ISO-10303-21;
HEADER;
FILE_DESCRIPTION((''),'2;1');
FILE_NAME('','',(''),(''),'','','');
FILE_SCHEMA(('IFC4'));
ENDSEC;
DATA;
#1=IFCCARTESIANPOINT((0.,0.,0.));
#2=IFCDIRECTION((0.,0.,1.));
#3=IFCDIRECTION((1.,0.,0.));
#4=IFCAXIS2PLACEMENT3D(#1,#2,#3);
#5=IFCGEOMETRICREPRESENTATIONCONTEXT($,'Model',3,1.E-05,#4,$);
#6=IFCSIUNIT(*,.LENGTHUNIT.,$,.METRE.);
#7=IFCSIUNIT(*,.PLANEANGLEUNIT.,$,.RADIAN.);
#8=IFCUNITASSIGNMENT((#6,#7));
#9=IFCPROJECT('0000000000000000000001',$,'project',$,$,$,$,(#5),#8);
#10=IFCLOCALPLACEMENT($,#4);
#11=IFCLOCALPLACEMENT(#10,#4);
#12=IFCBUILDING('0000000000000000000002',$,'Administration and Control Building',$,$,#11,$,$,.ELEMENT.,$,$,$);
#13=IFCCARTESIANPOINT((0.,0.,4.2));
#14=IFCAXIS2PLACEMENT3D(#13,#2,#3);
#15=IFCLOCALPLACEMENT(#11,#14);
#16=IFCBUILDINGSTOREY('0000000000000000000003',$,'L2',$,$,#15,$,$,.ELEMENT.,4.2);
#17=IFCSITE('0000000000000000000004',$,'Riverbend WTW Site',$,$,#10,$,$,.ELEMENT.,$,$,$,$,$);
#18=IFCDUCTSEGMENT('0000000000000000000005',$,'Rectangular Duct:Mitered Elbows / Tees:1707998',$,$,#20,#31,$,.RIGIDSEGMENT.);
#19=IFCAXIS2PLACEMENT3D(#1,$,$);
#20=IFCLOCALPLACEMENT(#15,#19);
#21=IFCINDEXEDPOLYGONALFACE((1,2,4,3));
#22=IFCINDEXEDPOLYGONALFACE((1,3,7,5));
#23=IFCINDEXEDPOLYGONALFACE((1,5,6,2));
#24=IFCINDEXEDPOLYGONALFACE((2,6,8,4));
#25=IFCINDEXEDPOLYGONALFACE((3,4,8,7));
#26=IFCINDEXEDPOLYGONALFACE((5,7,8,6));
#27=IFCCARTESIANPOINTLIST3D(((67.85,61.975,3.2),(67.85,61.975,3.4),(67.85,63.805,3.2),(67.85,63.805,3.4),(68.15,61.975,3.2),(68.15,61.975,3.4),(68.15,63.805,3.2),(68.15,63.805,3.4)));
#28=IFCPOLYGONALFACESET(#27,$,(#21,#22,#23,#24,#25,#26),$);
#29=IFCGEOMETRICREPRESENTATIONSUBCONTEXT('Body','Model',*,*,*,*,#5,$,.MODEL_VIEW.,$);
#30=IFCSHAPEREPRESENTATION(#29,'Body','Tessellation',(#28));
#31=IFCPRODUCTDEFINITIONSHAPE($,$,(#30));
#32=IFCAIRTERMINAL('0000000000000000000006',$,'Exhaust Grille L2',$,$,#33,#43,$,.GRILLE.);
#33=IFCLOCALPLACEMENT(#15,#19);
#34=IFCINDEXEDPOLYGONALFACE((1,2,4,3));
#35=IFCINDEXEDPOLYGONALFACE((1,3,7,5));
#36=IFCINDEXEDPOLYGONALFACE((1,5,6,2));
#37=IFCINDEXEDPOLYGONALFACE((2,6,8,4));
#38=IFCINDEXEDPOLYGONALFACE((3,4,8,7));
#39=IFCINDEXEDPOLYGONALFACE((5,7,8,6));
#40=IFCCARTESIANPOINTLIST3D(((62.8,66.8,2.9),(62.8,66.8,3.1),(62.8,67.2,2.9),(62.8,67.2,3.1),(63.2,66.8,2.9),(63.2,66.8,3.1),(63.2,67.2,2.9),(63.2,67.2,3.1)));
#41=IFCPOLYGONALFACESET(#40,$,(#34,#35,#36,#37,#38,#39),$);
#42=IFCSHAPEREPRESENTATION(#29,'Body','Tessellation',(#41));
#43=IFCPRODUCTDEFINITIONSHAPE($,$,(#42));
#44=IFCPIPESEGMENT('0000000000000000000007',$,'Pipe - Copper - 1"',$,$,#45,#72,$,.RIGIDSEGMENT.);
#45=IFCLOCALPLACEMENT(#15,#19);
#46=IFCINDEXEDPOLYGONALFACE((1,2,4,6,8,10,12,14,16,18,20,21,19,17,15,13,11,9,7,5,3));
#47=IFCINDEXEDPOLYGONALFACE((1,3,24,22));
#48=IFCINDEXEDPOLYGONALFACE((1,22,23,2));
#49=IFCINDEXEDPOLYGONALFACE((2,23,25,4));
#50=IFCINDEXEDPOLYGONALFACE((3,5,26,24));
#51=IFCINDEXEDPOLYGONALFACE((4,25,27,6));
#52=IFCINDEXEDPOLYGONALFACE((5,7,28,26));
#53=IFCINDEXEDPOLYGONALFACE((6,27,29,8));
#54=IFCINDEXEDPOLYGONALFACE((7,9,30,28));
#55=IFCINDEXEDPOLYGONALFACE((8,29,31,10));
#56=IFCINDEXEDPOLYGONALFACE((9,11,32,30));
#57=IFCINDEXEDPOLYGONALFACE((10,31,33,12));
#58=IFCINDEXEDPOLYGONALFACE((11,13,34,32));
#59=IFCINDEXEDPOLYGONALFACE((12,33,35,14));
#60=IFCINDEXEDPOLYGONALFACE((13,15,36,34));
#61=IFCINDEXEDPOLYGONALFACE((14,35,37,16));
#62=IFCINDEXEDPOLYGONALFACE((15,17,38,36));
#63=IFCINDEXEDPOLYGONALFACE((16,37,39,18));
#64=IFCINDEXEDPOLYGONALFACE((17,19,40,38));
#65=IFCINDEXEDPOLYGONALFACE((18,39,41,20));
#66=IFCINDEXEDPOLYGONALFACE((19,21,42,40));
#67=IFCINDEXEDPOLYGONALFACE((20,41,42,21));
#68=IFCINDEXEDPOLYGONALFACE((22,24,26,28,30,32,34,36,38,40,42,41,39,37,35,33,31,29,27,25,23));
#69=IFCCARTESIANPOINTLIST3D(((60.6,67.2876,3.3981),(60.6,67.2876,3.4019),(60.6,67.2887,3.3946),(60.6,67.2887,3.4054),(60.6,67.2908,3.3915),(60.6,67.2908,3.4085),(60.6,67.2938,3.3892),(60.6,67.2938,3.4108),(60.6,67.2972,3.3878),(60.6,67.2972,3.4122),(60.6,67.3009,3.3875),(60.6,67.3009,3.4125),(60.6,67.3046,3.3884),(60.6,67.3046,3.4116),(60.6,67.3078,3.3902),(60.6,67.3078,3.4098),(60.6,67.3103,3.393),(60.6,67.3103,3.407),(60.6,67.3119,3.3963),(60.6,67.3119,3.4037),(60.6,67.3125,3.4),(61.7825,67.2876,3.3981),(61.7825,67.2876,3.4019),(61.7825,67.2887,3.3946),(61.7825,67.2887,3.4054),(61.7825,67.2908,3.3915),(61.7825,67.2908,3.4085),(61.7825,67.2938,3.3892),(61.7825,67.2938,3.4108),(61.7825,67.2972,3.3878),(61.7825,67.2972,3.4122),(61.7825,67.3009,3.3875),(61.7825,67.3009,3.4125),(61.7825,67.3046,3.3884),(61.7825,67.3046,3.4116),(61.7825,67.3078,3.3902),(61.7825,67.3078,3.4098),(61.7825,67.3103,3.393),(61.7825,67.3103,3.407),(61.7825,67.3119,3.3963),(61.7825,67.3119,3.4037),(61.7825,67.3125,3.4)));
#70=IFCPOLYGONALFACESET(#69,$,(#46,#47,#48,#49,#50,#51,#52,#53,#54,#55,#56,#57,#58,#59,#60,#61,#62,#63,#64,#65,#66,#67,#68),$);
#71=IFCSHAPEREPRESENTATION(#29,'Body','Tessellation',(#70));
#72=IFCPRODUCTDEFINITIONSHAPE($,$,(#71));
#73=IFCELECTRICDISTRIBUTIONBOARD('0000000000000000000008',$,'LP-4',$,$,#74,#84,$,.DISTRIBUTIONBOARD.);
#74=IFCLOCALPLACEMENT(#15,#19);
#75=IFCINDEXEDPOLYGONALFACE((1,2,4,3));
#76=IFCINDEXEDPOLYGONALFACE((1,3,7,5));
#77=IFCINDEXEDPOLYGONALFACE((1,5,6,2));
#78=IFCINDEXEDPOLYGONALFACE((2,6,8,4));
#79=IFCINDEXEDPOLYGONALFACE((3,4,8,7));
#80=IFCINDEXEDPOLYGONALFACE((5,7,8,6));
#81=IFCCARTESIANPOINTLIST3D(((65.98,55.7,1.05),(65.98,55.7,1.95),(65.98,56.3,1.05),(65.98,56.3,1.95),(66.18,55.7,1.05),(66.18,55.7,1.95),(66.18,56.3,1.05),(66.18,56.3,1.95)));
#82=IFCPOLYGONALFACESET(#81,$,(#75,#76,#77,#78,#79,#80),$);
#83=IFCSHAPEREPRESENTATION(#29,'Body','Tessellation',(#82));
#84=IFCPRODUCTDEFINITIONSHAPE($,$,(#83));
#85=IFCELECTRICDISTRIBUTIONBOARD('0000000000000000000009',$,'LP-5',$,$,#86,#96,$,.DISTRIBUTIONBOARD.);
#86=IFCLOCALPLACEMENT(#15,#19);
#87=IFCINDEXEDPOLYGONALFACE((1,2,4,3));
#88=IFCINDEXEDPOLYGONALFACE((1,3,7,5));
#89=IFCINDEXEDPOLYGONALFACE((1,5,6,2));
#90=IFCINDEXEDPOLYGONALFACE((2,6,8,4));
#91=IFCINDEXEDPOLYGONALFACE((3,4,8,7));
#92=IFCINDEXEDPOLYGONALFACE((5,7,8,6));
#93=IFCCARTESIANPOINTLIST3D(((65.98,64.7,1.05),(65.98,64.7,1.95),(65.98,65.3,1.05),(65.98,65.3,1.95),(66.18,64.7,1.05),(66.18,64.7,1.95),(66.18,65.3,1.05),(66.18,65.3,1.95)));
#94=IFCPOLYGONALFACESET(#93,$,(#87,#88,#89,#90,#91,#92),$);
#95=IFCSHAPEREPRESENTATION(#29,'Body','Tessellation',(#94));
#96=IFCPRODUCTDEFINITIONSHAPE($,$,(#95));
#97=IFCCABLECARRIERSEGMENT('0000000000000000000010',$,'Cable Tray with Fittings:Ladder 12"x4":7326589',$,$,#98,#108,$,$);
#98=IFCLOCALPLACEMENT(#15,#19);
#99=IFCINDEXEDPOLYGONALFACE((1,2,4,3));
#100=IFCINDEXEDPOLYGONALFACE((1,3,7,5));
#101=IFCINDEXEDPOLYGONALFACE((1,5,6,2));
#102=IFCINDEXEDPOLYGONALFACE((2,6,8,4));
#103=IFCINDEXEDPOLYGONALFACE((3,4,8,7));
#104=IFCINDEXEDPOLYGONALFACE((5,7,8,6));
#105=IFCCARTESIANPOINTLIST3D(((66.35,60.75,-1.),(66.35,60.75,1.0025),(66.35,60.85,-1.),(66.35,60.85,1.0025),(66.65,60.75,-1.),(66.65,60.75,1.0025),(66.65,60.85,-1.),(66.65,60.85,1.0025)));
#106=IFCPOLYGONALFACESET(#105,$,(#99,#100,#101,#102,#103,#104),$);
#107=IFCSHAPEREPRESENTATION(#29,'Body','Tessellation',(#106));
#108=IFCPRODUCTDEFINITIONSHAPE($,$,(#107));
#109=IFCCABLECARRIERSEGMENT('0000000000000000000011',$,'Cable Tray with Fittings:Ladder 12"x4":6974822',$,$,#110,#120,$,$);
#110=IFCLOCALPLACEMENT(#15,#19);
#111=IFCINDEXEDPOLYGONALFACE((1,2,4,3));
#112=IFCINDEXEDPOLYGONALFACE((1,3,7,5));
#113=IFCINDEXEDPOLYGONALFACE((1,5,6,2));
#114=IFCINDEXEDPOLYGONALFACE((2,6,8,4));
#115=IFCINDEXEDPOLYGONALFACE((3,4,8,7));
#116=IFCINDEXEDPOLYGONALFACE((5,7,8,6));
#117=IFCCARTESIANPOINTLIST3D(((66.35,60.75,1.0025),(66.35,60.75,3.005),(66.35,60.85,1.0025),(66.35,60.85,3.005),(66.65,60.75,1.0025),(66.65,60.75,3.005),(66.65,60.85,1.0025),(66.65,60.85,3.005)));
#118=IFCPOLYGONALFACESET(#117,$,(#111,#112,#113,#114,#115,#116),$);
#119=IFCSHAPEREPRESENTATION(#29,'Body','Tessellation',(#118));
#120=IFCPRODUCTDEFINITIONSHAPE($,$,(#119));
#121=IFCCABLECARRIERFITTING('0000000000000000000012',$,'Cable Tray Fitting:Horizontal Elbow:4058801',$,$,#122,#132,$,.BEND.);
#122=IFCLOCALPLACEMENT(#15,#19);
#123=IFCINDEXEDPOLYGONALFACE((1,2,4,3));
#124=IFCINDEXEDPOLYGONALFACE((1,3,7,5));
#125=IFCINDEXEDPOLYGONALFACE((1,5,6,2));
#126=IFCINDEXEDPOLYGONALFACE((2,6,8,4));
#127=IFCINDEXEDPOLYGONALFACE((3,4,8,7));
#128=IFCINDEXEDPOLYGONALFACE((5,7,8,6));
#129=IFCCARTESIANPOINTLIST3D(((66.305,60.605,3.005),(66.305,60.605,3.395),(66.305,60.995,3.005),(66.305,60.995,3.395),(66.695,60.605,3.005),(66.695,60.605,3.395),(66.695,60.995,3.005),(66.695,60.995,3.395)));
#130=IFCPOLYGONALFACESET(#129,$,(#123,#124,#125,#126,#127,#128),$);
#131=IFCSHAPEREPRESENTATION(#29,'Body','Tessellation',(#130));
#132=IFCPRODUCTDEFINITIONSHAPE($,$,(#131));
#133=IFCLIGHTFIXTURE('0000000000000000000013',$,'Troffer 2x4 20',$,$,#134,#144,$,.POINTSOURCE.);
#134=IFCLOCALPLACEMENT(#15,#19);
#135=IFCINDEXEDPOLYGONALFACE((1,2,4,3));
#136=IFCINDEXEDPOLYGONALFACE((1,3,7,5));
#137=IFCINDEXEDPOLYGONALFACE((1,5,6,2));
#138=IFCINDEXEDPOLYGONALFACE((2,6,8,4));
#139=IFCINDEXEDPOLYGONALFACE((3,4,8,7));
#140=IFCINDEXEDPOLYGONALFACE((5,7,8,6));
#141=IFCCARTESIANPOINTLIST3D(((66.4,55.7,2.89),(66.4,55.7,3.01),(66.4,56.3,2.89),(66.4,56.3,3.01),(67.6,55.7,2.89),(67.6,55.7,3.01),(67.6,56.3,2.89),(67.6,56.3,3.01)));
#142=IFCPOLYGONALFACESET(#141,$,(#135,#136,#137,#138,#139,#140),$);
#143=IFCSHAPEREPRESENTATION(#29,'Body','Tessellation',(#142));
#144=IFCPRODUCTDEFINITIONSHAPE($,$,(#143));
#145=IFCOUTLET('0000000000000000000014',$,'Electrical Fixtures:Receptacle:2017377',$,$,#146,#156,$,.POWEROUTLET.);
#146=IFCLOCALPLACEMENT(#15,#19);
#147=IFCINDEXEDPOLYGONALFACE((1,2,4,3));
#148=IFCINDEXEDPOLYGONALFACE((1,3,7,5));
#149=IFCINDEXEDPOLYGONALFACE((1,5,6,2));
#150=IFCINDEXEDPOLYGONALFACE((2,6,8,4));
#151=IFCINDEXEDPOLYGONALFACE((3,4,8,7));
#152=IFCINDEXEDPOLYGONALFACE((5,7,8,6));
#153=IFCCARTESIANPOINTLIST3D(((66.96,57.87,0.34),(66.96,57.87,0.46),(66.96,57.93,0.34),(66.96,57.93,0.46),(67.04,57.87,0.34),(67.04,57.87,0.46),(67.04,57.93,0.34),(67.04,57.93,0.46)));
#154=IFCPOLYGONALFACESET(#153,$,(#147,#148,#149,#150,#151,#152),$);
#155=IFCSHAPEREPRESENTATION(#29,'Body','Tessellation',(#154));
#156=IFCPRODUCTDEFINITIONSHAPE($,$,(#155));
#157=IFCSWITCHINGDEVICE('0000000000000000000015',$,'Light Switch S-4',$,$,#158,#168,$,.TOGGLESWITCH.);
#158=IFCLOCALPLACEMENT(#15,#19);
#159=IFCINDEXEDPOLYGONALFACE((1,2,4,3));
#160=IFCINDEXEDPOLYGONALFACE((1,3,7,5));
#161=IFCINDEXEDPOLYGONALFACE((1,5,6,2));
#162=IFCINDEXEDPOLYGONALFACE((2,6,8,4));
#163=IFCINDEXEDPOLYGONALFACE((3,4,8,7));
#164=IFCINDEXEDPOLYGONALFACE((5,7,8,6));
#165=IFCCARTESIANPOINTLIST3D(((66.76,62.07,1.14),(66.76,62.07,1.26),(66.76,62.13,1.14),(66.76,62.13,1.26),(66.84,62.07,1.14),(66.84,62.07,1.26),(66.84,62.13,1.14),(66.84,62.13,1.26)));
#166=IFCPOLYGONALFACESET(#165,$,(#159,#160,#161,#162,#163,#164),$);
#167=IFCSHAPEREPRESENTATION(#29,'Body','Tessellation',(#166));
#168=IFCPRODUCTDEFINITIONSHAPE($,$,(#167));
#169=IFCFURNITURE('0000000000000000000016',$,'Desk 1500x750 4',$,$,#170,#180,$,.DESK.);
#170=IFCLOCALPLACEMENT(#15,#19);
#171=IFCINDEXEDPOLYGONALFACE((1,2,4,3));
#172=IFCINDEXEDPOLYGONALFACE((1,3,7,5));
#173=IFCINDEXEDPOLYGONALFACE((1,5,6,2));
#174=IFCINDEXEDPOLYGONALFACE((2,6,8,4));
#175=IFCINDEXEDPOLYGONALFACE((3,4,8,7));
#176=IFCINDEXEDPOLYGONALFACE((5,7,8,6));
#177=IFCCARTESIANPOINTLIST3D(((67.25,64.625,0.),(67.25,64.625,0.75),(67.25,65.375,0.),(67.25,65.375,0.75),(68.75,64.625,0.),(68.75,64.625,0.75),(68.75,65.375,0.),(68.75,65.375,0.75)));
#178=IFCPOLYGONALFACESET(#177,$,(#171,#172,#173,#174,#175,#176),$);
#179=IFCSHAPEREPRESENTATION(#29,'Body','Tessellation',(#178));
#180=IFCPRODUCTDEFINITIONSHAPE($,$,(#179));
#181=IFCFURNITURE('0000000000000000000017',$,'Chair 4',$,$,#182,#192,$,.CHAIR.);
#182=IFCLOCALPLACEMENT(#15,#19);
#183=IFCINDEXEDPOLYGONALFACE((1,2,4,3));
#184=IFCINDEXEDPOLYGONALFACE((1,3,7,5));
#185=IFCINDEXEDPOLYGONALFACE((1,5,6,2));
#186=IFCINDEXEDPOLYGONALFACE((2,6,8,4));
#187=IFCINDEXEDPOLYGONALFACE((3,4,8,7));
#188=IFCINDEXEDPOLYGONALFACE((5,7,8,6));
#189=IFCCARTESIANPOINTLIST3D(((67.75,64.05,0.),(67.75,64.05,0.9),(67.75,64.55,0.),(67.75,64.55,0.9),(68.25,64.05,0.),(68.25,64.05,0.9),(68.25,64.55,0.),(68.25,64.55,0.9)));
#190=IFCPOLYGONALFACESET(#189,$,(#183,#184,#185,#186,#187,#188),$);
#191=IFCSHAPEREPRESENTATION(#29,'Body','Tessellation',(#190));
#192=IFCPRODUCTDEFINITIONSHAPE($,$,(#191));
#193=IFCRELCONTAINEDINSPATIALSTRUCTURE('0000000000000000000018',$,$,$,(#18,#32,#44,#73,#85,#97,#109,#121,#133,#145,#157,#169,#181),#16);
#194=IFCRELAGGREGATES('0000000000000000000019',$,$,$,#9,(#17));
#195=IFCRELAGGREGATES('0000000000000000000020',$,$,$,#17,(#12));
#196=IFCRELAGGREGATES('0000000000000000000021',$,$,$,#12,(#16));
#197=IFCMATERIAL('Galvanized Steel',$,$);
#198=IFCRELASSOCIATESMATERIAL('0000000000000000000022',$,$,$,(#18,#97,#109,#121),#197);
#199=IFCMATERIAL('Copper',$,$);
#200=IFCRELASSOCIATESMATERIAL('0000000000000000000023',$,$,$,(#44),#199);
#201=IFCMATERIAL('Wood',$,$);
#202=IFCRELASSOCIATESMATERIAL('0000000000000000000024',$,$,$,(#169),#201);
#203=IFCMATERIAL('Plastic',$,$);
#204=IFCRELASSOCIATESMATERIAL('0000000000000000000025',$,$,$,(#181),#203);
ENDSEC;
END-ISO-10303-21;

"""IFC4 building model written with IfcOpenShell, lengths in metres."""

from ifc_helpers import new_model, si_unit, frame, origin_with_axes, origin_2d, place, context, subcontext, project, spatial, rectangle, circle, extrude, material, element, save


model = new_model("IFC4")

# Units and contexts
model_context = context("Model", 3, precision=1e-05, world=origin_with_axes())
body_context = subcontext(model_context, "Body", "Model", "MODEL_VIEW")
ifc_project = project(units=[si_unit("LENGTHUNIT", "METRE"), si_unit("PLANEANGLEUNIT", "RADIAN")], contexts=[model_context])

# Site, building, storey
site_placement = place(None, origin_with_axes())
site = spatial("IfcSite", under=ifc_project, at=site_placement, Name="Riverbend WTW Site", CompositionType="ELEMENT")
building_placement = place(site_placement, origin_with_axes())
building = spatial("IfcBuilding", under=site, at=building_placement, Name="Administration and Control Building", CompositionType="ELEMENT")
storey_placement = place(building_placement, frame((0.0, 0.0, 4.2), z_axis=(0.0, 0.0, 1.0), x_axis=(1.0, 0.0, 0.0)))
storey = spatial("IfcBuildingStorey", under=building, at=storey_placement, Name="L2", CompositionType="ELEMENT", Elevation=4.2)

# Duct segment
ifc_material_1 = material(Name="Galvanized Steel")
duct_segment_1_placement = place(None, frame((68.0, 62.89, 7.5), z_axis=(0.0, 0.0, 1.0), x_axis=(1.0, 0.0, 0.0)))
element("IfcDuctSegment", 1, at=duct_segment_1_placement, inside=storey, material=ifc_material_1, Name="Rectangular Duct:Mitered Elbows / Tees:1707998", PredefinedType="RIGIDSEGMENT", context=body_context, shape_type="SweptSolid", body=[
    extrude(rectangle(XDim=0.3, YDim=1.83, at=origin_2d()), frame((0.0, 0.0, -0.1), z_axis=(0.0, 0.0, 1.0), x_axis=(1.0, 0.0, 0.0)), (0.0, 0.0, 1.0), 0.2),
])

# Air terminal
air_terminal_placement = place(None, frame((63.0, 67.0, 7.2), z_axis=(0.0, 0.0, 1.0), x_axis=(1.0, 0.0, 0.0)))
element("IfcAirTerminal", 2, at=air_terminal_placement, inside=storey, Name="Exhaust Grille L2", PredefinedType="GRILLE", context=body_context, shape_type="SweptSolid", body=[
    extrude(rectangle(XDim=0.4, YDim=0.4, at=origin_2d()), frame((0.0, 0.0, -0.1), z_axis=(0.0, 0.0, 1.0), x_axis=(1.0, 0.0, 0.0)), (0.0, 0.0, 1.0), 0.2),
])

# Pipe segment
ifc_material_2 = material(Name="Copper")
pipe_segment_placement = place(None, frame((60.6, 67.3, 7.6), z_axis=(0.0, 0.0, 1.0), x_axis=(1.0, 0.0, 0.0)))
element("IfcPipeSegment", 3, at=pipe_segment_placement, inside=storey, material=ifc_material_2, Name="Pipe - Copper - 1\"", PredefinedType="RIGIDSEGMENT", context=body_context, shape_type="SweptSolid", body=[
    extrude(circle(Radius=0.0125, at=origin_2d()), frame((0.0, 0.0, 0.0), z_axis=(1.0, 0.0, 0.0), x_axis=(0.0, 1.0, 0.0)), (0.0, 0.0, 1.0), 1.1825),
])

# Electric distribution boards
for number, where, z_axis, x_axis, name in (
    (4, (66.08, 56.0, 5.7), (0.0, 0.0, 1.0), (1.0, 0.0, 0.0), "LP-4"),
    (5, (66.08, 65.0, 5.7), (0.0, 0.0, 1.0), (1.0, 0.0, 0.0), "LP-5"),
):
    element("IfcElectricDistributionBoard", number, at=place(None, frame(where, z_axis=z_axis, x_axis=x_axis)), inside=storey, Name=name, PredefinedType="DISTRIBUTIONBOARD", context=body_context, shape_type="SweptSolid", body=[
        extrude(rectangle(XDim=0.2, YDim=0.6, at=origin_2d()), frame((0.0, 0.0, -0.45), z_axis=(0.0, 0.0, 1.0), x_axis=(1.0, 0.0, 0.0)), (0.0, 0.0, 1.0), 0.9),
    ])

# Cable carrier segments
cable_carrier_segment_1_placement = place(None, frame((66.5, 60.8, 4.2012), z_axis=(0.0, 0.0, 1.0), x_axis=(1.0, 0.0, 0.0)))
element("IfcCableCarrierSegment", 6, at=cable_carrier_segment_1_placement, inside=storey, material=ifc_material_1, Name="Cable Tray with Fittings:Ladder 12\"x4\":7326589", context=body_context, shape_type="SweptSolid", body=[
    extrude(rectangle(XDim=0.3, YDim=0.1, at=origin_2d()), frame((0.0, 0.0, -1.0013), z_axis=(0.0, 0.0, 1.0), x_axis=(1.0, 0.0, 0.0)), (0.0, 0.0, 1.0), 2.0025),
])
cable_carrier_segment_2_placement = place(None, frame((66.5, 60.8, 6.2038), z_axis=(0.0, 0.0, 1.0), x_axis=(1.0, 0.0, 0.0)))
element("IfcCableCarrierSegment", 7, at=cable_carrier_segment_2_placement, inside=storey, material=ifc_material_1, Name="Cable Tray with Fittings:Ladder 12\"x4\":6974822", context=body_context, shape_type="SweptSolid", body=[
    extrude(rectangle(XDim=0.3, YDim=0.1, at=origin_2d()), frame((0.0, 0.0, -1.0012), z_axis=(0.0, 0.0, 1.0), x_axis=(1.0, 0.0, 0.0)), (0.0, 0.0, 1.0), 2.0025),
])

# Cable carrier fitting
cable_carrier_fitting_placement = place(None, frame((66.5, 60.8, 7.4), z_axis=(0.0, 0.0, 1.0), x_axis=(1.0, 0.0, 0.0)))
element("IfcCableCarrierFitting", 8, at=cable_carrier_fitting_placement, inside=storey, material=ifc_material_1, Name="Cable Tray Fitting:Horizontal Elbow:4058801", PredefinedType="BEND", context=body_context, shape_type="SweptSolid", body=[
    extrude(rectangle(XDim=0.39, YDim=0.39, at=origin_2d()), frame((0.0, 0.0, -0.195), z_axis=(0.0, 0.0, 1.0), x_axis=(1.0, 0.0, 0.0)), (0.0, 0.0, 1.0), 0.39),
])

# Light fixture
light_fixture_placement = place(None, frame((67.0, 56.0, 7.15), z_axis=(0.0, 0.0, 1.0), x_axis=(1.0, 0.0, 0.0)))
element("IfcLightFixture", 9, at=light_fixture_placement, inside=storey, Name="Troffer 2x4 20", PredefinedType="POINTSOURCE", context=body_context, shape_type="SweptSolid", body=[
    extrude(rectangle(XDim=1.2, YDim=0.6, at=origin_2d()), frame((0.0, 0.0, -0.06), z_axis=(0.0, 0.0, 1.0), x_axis=(1.0, 0.0, 0.0)), (0.0, 0.0, 1.0), 0.12),
])

# Outlet
outlet_placement = place(None, frame((67.0, 57.9, 4.6), z_axis=(0.0, 0.0, 1.0), x_axis=(1.0, 0.0, 0.0)))
element("IfcOutlet", 10, at=outlet_placement, inside=storey, Name="Electrical Fixtures:Receptacle:2017377", PredefinedType="POWEROUTLET", context=body_context, shape_type="SweptSolid", body=[
    extrude(rectangle(XDim=0.08, YDim=0.06, at=origin_2d()), frame((0.0, 0.0, -0.06), z_axis=(0.0, 0.0, 1.0), x_axis=(1.0, 0.0, 0.0)), (0.0, 0.0, 1.0), 0.12),
])

# Switching device
switching_device_placement = place(None, frame((66.8, 62.1, 5.4), z_axis=(0.0, 0.0, 1.0), x_axis=(1.0, 0.0, 0.0)))
element("IfcSwitchingDevice", 11, at=switching_device_placement, inside=storey, Name="Light Switch S-4", PredefinedType="TOGGLESWITCH", context=body_context, shape_type="SweptSolid", body=[
    extrude(rectangle(XDim=0.08, YDim=0.06, at=origin_2d()), frame((0.0, 0.0, -0.06), z_axis=(0.0, 0.0, 1.0), x_axis=(1.0, 0.0, 0.0)), (0.0, 0.0, 1.0), 0.12),
])

# Furniture
ifc_material_3 = material(Name="Wood")
furniture_1_placement = place(None, frame((68.0, 65.0, 4.575), z_axis=(0.0, 0.0, 1.0), x_axis=(1.0, 0.0, 0.0)))
element("IfcFurniture", 12, at=furniture_1_placement, inside=storey, material=ifc_material_3, Name="Desk 1500x750 4", PredefinedType="DESK", context=body_context, shape_type="SweptSolid", body=[
    extrude(rectangle(XDim=1.5, YDim=0.75, at=origin_2d()), frame((0.0, 0.0, -0.375), z_axis=(0.0, 0.0, 1.0), x_axis=(1.0, 0.0, 0.0)), (0.0, 0.0, 1.0), 0.75),
])
ifc_material_4 = material(Name="Plastic")
furniture_2_placement = place(None, frame((68.0, 64.3, 4.65), z_axis=(0.0, 0.0, 1.0), x_axis=(1.0, 0.0, 0.0)))
element("IfcFurniture", 13, at=furniture_2_placement, inside=storey, material=ifc_material_4, Name="Chair 4", PredefinedType="CHAIR", context=body_context, shape_type="SweptSolid", body=[
    extrude(rectangle(XDim=0.5, YDim=0.5, at=origin_2d()), frame((0.0, 0.0, -0.45), z_axis=(0.0, 0.0, 1.0), x_axis=(1.0, 0.0, 0.0)), (0.0, 0.0, 1.0), 0.9),
])

save(model, "model.ifc")
